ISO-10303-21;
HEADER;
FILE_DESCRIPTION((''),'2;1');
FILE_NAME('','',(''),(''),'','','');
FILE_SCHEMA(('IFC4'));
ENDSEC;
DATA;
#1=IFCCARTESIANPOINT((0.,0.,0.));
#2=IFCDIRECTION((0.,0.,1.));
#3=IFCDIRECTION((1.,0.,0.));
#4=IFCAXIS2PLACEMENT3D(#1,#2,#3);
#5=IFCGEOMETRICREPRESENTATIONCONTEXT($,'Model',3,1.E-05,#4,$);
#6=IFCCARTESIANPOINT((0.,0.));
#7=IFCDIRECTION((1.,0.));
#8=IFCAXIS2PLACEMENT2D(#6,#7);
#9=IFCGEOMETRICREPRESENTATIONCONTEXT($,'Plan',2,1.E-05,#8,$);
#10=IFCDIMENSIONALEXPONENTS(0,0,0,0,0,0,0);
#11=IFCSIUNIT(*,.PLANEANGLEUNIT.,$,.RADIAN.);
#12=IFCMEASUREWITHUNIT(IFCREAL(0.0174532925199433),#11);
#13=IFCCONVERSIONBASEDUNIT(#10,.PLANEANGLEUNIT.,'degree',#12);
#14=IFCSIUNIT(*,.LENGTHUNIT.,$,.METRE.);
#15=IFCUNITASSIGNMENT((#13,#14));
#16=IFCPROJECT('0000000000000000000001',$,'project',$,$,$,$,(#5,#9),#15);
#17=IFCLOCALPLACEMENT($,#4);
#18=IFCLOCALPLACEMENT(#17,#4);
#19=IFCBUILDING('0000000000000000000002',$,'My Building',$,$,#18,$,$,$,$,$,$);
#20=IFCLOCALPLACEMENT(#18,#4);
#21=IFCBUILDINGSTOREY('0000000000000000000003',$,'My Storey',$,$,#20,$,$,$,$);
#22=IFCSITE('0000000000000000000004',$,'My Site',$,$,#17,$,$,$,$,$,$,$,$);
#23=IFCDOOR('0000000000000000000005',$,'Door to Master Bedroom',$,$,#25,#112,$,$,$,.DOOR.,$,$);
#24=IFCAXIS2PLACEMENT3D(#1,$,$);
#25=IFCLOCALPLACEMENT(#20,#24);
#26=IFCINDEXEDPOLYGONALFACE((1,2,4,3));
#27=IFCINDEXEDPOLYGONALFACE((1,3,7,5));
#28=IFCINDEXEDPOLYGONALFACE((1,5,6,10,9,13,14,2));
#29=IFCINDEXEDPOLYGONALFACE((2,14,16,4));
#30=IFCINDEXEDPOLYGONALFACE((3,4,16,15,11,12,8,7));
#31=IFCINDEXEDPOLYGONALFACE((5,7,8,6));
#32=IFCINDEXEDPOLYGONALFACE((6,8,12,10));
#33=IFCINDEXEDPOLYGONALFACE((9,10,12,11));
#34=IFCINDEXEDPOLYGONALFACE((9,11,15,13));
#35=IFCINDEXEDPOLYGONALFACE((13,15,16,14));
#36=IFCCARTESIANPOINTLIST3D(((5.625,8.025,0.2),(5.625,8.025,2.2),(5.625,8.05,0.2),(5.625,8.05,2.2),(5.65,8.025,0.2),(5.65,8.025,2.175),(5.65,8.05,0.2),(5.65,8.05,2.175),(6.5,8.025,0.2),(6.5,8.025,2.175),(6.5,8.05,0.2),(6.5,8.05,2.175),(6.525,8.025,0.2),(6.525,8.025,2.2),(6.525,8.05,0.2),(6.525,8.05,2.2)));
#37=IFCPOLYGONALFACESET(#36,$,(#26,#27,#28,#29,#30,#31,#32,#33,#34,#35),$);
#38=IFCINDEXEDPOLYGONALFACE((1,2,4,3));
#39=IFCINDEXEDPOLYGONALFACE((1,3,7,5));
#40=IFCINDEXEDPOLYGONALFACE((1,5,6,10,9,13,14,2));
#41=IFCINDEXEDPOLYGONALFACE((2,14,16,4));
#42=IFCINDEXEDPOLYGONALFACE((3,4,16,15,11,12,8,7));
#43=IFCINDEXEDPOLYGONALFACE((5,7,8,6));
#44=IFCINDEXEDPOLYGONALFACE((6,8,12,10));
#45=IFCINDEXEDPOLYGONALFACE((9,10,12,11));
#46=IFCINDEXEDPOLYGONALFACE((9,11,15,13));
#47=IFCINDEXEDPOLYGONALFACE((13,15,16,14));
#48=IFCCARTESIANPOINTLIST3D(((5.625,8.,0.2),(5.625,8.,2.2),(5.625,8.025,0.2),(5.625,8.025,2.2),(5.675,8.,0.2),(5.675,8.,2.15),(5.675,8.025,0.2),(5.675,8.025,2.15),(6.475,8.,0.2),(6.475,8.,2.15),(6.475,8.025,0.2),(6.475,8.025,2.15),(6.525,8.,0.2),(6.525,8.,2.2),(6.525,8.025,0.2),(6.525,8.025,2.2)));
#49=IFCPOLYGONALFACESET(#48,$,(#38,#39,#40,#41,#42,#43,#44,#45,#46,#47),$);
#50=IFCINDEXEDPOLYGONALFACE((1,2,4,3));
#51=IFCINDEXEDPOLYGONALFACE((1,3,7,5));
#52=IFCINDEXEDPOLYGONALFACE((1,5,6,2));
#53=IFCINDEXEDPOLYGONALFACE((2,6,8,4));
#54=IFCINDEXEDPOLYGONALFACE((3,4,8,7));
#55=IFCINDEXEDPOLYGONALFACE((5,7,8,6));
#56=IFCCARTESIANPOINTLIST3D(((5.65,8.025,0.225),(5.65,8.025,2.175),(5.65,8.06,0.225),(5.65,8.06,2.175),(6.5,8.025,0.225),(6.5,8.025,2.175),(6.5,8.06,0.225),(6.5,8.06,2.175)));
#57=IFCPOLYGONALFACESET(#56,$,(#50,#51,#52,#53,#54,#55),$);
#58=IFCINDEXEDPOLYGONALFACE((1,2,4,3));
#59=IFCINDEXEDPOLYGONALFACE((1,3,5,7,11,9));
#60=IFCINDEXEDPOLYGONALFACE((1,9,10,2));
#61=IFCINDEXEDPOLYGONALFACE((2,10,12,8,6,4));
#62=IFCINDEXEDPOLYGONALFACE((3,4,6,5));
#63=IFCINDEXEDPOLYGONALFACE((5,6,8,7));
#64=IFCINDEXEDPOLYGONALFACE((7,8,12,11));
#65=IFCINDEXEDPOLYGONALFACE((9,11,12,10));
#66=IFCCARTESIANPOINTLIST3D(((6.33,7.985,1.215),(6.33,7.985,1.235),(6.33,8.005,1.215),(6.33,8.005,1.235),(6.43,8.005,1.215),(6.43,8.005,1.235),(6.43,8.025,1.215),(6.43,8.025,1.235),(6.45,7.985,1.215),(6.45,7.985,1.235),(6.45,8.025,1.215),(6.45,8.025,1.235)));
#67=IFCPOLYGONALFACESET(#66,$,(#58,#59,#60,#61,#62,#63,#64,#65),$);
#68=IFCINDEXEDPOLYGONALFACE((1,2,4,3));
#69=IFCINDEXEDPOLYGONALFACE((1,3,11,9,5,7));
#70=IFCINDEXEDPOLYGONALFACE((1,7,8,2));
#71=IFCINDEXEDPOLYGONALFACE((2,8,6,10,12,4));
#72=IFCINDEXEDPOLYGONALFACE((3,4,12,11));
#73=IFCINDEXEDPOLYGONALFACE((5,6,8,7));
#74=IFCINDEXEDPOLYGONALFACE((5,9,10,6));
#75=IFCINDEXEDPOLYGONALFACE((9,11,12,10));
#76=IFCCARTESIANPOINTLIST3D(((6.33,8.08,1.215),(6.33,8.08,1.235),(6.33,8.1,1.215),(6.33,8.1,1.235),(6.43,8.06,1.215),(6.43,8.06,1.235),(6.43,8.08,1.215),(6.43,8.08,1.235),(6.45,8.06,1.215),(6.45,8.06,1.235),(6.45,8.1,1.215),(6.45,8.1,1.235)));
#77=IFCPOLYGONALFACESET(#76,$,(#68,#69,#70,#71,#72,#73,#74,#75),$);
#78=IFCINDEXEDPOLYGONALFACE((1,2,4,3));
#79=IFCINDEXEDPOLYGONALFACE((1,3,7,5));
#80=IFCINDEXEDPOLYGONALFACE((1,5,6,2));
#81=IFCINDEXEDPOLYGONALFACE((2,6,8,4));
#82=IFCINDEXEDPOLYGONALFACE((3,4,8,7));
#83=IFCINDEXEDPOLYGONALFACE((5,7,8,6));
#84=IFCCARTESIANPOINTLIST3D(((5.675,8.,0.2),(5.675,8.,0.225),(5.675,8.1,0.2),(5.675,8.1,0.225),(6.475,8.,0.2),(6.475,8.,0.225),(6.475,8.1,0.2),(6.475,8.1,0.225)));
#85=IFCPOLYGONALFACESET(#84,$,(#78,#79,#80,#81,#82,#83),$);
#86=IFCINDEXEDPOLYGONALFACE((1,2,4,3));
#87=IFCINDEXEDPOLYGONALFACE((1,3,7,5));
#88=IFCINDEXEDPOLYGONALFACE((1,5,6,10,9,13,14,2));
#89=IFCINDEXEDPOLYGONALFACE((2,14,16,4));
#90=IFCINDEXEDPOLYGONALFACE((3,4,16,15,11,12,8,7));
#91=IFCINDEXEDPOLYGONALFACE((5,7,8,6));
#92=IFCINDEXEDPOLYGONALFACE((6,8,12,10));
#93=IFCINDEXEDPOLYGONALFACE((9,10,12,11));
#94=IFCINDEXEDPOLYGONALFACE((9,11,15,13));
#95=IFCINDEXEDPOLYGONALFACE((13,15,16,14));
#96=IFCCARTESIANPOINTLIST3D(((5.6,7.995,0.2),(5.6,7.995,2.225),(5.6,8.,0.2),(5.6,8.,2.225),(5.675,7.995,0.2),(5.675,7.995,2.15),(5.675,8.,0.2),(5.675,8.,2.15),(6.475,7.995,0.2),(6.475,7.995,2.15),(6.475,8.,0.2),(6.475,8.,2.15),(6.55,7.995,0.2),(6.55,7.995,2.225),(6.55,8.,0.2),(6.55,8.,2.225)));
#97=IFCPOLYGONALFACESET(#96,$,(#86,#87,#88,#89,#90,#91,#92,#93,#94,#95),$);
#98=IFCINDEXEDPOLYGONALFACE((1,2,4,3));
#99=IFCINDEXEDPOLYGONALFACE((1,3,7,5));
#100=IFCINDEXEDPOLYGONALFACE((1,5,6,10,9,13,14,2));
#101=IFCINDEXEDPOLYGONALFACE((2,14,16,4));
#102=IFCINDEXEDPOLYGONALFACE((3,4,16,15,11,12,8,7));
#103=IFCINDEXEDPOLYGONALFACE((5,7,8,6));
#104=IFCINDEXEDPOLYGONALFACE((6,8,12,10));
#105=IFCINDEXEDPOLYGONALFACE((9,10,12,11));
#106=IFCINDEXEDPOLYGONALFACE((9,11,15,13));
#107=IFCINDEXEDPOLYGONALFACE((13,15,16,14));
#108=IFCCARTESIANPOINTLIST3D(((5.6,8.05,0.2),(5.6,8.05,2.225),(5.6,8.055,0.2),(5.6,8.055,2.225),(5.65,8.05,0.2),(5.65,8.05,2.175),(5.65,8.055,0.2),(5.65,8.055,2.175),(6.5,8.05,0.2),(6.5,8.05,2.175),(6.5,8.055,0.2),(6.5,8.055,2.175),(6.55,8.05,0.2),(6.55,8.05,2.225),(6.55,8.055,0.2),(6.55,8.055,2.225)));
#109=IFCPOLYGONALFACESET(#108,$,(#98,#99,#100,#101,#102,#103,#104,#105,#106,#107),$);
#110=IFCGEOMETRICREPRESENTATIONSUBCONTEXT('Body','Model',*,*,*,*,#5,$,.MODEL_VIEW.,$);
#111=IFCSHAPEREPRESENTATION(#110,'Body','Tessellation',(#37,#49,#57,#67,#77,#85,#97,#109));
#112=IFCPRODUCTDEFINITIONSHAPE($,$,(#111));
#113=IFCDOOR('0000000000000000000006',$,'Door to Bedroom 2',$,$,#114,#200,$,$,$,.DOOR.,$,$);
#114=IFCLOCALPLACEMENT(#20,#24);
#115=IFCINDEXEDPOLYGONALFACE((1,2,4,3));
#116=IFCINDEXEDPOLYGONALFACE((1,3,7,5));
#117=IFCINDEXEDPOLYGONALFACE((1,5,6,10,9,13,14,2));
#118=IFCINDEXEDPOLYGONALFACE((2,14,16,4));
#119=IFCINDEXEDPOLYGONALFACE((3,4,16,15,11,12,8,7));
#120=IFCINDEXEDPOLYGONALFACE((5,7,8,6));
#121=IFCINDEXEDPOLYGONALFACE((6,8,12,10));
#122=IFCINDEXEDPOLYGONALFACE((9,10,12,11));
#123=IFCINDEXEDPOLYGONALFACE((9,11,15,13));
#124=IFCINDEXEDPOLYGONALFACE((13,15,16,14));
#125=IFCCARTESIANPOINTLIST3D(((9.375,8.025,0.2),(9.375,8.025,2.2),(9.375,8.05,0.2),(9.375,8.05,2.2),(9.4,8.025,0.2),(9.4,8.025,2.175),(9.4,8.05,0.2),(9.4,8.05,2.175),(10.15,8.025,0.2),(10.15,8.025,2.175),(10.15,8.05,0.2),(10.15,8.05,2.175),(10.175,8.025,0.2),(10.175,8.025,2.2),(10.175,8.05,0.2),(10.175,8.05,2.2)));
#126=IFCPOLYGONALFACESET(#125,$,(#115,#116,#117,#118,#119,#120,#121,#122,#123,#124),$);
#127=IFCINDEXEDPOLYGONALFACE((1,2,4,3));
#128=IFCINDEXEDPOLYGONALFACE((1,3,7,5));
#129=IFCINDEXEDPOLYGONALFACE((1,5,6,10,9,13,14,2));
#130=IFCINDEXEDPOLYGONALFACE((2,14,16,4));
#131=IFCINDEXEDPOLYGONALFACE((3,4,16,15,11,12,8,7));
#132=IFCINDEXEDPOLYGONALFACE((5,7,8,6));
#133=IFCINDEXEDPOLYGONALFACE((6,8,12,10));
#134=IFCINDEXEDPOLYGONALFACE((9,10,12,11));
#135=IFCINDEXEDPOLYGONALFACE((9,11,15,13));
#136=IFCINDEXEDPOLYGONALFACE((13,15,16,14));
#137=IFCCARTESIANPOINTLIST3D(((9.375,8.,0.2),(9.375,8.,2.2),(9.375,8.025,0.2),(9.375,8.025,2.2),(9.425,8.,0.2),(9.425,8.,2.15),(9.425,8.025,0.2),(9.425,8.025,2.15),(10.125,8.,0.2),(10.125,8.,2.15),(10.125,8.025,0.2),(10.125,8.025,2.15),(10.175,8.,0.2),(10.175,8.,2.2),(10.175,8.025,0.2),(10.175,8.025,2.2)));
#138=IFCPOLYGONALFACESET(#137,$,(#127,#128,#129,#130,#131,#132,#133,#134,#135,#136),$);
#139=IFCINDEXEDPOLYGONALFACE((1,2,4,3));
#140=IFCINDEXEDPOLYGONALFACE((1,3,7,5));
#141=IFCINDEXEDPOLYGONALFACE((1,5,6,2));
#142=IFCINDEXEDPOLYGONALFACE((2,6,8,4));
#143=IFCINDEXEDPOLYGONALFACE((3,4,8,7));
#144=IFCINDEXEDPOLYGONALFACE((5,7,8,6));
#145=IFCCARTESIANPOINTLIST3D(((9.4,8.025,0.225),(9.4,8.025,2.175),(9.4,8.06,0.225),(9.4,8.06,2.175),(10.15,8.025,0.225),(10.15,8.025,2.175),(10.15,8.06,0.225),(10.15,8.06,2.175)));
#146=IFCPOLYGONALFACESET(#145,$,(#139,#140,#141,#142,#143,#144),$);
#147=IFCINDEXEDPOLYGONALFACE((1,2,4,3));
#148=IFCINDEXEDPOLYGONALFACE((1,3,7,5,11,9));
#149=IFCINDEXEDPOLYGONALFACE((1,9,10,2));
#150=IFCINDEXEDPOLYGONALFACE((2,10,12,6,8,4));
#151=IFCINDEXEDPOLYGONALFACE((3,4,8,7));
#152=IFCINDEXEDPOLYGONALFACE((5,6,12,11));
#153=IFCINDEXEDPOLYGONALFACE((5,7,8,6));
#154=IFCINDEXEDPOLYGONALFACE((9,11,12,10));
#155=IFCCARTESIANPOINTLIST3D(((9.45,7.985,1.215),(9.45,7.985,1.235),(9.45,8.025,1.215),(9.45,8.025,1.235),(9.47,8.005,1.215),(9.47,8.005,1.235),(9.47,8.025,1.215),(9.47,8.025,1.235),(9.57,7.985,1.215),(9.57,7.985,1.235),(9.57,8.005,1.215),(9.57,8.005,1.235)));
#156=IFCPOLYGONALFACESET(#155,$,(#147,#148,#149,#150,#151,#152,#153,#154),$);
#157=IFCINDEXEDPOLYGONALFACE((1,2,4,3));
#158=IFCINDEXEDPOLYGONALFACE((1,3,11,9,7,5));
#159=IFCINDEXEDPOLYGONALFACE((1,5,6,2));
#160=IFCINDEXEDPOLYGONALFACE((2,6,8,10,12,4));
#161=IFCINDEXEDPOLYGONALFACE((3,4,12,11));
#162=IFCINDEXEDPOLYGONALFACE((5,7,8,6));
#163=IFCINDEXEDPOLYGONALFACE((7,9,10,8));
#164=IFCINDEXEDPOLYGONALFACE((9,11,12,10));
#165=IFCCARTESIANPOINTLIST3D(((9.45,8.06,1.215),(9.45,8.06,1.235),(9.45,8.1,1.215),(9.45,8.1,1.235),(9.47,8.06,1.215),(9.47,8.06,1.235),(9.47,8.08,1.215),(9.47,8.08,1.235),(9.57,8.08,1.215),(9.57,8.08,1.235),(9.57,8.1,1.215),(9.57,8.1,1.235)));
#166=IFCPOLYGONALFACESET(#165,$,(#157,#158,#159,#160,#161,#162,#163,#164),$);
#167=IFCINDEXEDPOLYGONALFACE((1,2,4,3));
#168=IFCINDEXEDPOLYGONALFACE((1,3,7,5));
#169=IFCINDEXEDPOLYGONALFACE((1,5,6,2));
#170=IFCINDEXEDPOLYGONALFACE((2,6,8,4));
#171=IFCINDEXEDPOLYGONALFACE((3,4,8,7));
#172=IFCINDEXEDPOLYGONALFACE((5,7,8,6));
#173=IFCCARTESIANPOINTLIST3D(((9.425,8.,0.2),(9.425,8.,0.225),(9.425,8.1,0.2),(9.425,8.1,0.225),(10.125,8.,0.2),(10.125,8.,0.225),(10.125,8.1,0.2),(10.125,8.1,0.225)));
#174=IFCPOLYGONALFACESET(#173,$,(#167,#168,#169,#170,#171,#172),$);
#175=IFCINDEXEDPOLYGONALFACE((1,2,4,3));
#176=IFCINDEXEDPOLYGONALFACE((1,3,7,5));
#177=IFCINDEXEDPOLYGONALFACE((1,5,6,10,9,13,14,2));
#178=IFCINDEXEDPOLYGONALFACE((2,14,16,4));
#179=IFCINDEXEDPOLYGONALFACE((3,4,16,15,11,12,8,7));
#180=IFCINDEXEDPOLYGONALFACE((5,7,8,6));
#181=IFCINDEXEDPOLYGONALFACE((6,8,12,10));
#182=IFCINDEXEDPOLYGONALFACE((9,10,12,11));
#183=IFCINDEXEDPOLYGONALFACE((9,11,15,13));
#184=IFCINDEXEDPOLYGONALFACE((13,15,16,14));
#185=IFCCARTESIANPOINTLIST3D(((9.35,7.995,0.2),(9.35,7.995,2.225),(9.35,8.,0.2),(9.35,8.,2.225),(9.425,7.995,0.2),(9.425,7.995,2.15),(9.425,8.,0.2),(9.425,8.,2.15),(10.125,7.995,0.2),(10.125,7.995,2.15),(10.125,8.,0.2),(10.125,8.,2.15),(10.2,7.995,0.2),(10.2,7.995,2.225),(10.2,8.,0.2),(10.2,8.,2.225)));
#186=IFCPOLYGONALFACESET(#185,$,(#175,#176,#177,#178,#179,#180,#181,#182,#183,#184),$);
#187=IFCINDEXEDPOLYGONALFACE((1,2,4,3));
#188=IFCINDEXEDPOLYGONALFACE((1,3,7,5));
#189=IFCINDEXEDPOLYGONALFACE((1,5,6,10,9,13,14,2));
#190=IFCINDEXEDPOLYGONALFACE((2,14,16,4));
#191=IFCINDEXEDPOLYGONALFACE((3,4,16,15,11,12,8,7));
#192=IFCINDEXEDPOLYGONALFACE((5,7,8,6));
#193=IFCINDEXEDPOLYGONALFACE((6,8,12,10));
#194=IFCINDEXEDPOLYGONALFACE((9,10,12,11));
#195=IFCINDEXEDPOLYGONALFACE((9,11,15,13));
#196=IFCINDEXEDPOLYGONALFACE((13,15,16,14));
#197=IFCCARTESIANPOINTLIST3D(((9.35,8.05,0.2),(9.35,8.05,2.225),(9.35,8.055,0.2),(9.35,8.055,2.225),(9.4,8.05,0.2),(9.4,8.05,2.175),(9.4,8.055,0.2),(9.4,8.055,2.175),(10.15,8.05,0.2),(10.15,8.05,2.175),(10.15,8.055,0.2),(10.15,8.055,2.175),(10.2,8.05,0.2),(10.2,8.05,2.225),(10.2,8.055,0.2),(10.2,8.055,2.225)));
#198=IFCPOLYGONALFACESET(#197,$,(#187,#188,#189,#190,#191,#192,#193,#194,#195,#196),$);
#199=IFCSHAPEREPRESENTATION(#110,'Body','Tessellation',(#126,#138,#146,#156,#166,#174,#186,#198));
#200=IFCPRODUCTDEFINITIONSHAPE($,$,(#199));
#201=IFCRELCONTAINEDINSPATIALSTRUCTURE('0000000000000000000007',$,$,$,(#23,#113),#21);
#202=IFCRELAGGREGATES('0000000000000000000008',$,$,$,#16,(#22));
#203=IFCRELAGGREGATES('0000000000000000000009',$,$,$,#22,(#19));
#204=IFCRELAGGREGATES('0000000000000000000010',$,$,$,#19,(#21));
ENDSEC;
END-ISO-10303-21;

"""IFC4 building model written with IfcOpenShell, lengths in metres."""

from ifc_helpers import new_model, entity, si_unit, converted_unit, frame, origin_with_axes, origin_2d_with_axis, place, context, subcontext, project, spatial, line, indexed_curve, outline, extrude, element, save


model = new_model("IFC4")

# Units and contexts
model_context = context("Model", 3, precision=1e-05, world=origin_with_axes())
plan_context = context("Plan", 2, precision=1e-05, world=origin_2d_with_axis())
body_context = subcontext(model_context, "Body", "Model", "MODEL_VIEW")
ifc_project = project(units=[converted_unit("PLANEANGLEUNIT", "degree", entity("IfcReal", 0.0174532925199433), si_unit("PLANEANGLEUNIT", "RADIAN"), dimensions=[0, 0, 0, 0, 0, 0, 0]), si_unit("LENGTHUNIT", "METRE")], contexts=[model_context, plan_context])

# Site, building, storey
site_placement = place(None, origin_with_axes())
site = spatial("IfcSite", under=ifc_project, at=site_placement, Name="My Site")
building_placement = place(site_placement, origin_with_axes())
building = spatial("IfcBuilding", under=site, at=building_placement, Name="My Building")
storey_placement = place(building_placement, origin_with_axes())
storey = spatial("IfcBuildingStorey", under=building, at=storey_placement, Name="My Storey")

# Doors
door_1_placement = place(storey_placement, frame((5.625, 8.0, 0.2), z_axis=(0.0, 0.0, 1.0), x_axis=(1.0, 0.0, 0.0)))
element("IfcDoor", 1, at=door_1_placement, inside=storey, Name="Door to Master Bedroom", PredefinedType="DOOR", context=body_context, shape_type="SweptSolid", body=[
    extrude(outline(indexed_curve([(0.0, 0.0), (0.0, 2.0), (0.9, 2.0), (0.9, 0.0), (0.875, 0.0), (0.875, 1.975), (0.025, 1.975), (0.025, 0.0)], segments=[line(1, 2, 3, 4, 5, 6, 7, 8, 1)])), frame((0.0, 0.025, 0.0), z_axis=(0.0, -1.0, 0.0), x_axis=(1.0, 0.0, 0.0)), (0.0, 0.0, -1.0), 0.025),
    extrude(outline(indexed_curve([(0.0, 0.0), (0.0, 2.0), (0.9, 2.0), (0.9, 0.0), (0.85, 0.0), (0.85, 1.95), (0.05, 1.95), (0.05, 0.0)], segments=[line(1, 2, 3, 4, 5, 6, 7, 8, 1)])), frame((0.0, 0.0, 0.0), z_axis=(0.0, -1.0, 0.0), x_axis=(1.0, 0.0, 0.0)), (0.0, 0.0, -1.0), 0.025),
    extrude(outline(indexed_curve([(0.0, 0.0), (0.85, 0.0), (0.85, 0.035), (0.0, 0.035)], segments=[line(1, 2, 3, 4, 1)])), frame((0.025, 0.025, 0.025), z_axis=(0.0, 0.0, 1.0), x_axis=(1.0, 0.0, 0.0)), (0.0, 0.0, 1.0), 1.95),
    extrude(outline(indexed_curve([(0.0, 0.0), (0.0, -0.04), (-0.12, -0.04), (-0.12, -0.02), (-0.02, -0.02), (-0.02, 0.0)], segments=[line(1, 2, 3, 4, 5, 6, 1)])), frame((0.825, 0.025, 1.015), z_axis=(0.0, 0.0, 1.0), x_axis=(1.0, 0.0, 0.0)), (0.0, 0.0, 1.0), 0.02),
    extrude(outline(indexed_curve([(0.0, 0.0), (0.0, 0.04), (-0.12, 0.04), (-0.12, 0.02), (-0.02, 0.02), (-0.02, 0.0)], segments=[line(1, 2, 3, 4, 5, 6, 1)])), frame((0.825, 0.06, 1.015), z_axis=(0.0, 0.0, 1.0), x_axis=(1.0, 0.0, 0.0)), (0.0, 0.0, 1.0), 0.02),
    extrude(outline(indexed_curve([(0.0, 0.0), (0.8, 0.0), (0.8, 0.1), (0.0, 0.1)], segments=[line(1, 2, 3, 4, 1)])), frame((0.05, 0.0, 0.0), z_axis=(0.0, 0.0, 1.0), x_axis=(1.0, 0.0, 0.0)), (0.0, 0.0, 1.0), 0.025),
    extrude(outline(indexed_curve([(0.0, 0.0), (0.0, 2.025), (0.95, 2.025), (0.95, 0.0), (0.875, 0.0), (0.875, 1.95), (0.075, 1.95), (0.075, 0.0)], segments=[line(1, 2, 3, 4, 5, 6, 7, 8, 1)])), frame((-0.025, -0.005, 0.0), z_axis=(0.0, -1.0, 0.0), x_axis=(1.0, 0.0, 0.0)), (0.0, 0.0, -1.0), 0.005),
    extrude(outline(indexed_curve([(0.0, 0.0), (0.0, 2.025), (0.95, 2.025), (0.95, 0.0), (0.9, 0.0), (0.9, 1.975), (0.05, 1.975), (0.05, 0.0)], segments=[line(1, 2, 3, 4, 5, 6, 7, 8, 1)])), frame((-0.025, 0.05, 0.0), z_axis=(0.0, -1.0, 0.0), x_axis=(1.0, 0.0, 0.0)), (0.0, 0.0, -1.0), 0.005),
])
door_2_placement = place(storey_placement, frame((9.375, 8.0, 0.2), z_axis=(0.0, 0.0, 1.0), x_axis=(1.0, 0.0, 0.0)))
element("IfcDoor", 2, at=door_2_placement, inside=storey, Name="Door to Bedroom 2", PredefinedType="DOOR", context=body_context, shape_type="SweptSolid", body=[
    extrude(outline(indexed_curve([(0.0, 0.0), (0.0, 2.0), (0.8, 2.0), (0.8, 0.0), (0.775, 0.0), (0.775, 1.975), (0.025, 1.975), (0.025, 0.0)], segments=[line(1, 2, 3, 4, 5, 6, 7, 8, 1)])), frame((0.0, 0.025, 0.0), z_axis=(0.0, -1.0, 0.0), x_axis=(1.0, 0.0, 0.0)), (0.0, 0.0, -1.0), 0.025),
    extrude(outline(indexed_curve([(0.0, 0.0), (0.0, 2.0), (0.8, 2.0), (0.8, 0.0), (0.75, 0.0), (0.75, 1.95), (0.05, 1.95), (0.05, 0.0)], segments=[line(1, 2, 3, 4, 5, 6, 7, 8, 1)])), frame((0.0, 0.0, 0.0), z_axis=(0.0, -1.0, 0.0), x_axis=(1.0, 0.0, 0.0)), (0.0, 0.0, -1.0), 0.025),
    extrude(outline(indexed_curve([(0.0, 0.0), (0.75, 0.0), (0.75, 0.035), (0.0, 0.035)], segments=[line(1, 2, 3, 4, 1)])), frame((0.025, 0.025, 0.025), z_axis=(0.0, 0.0, 1.0), x_axis=(1.0, 0.0, 0.0)), (0.0, 0.0, 1.0), 1.95),
    extrude(outline(indexed_curve([(0.0, 0.0), (0.0, -0.04), (0.12, -0.04), (0.12, -0.02), (0.02, -0.02), (0.02, 0.0)], segments=[line(1, 2, 3, 4, 5, 6, 1)])), frame((0.075, 0.025, 1.015), z_axis=(0.0, 0.0, 1.0), x_axis=(1.0, 0.0, 0.0)), (0.0, 0.0, 1.0), 0.02),
    extrude(outline(indexed_curve([(0.0, 0.0), (0.0, 0.04), (0.12, 0.04), (0.12, 0.02), (0.02, 0.02), (0.02, 0.0)], segments=[line(1, 2, 3, 4, 5, 6, 1)])), frame((0.075, 0.06, 1.015), z_axis=(0.0, 0.0, 1.0), x_axis=(1.0, 0.0, 0.0)), (0.0, 0.0, 1.0), 0.02),
    extrude(outline(indexed_curve([(0.0, 0.0), (0.7, 0.0), (0.7, 0.1), (0.0, 0.1)], segments=[line(1, 2, 3, 4, 1)])), frame((0.05, 0.0, 0.0), z_axis=(0.0, 0.0, 1.0), x_axis=(1.0, 0.0, 0.0)), (0.0, 0.0, 1.0), 0.025),
    extrude(outline(indexed_curve([(0.0, 0.0), (0.0, 2.025), (0.85, 2.025), (0.85, 0.0), (0.775, 0.0), (0.775, 1.95), (0.075, 1.95), (0.075, 0.0)], segments=[line(1, 2, 3, 4, 5, 6, 7, 8, 1)])), frame((-0.025, -0.005, 0.0), z_axis=(0.0, -1.0, 0.0), x_axis=(1.0, 0.0, 0.0)), (0.0, 0.0, -1.0), 0.005),
    extrude(outline(indexed_curve([(0.0, 0.0), (0.0, 2.025), (0.85, 2.025), (0.85, 0.0), (0.8, 0.0), (0.8, 1.975), (0.05, 1.975), (0.05, 0.0)], segments=[line(1, 2, 3, 4, 5, 6, 7, 8, 1)])), frame((-0.025, 0.05, 0.0), z_axis=(0.0, -1.0, 0.0), x_axis=(1.0, 0.0, 0.0)), (0.0, 0.0, -1.0), 0.005),
])

save(model, "model.ifc")
